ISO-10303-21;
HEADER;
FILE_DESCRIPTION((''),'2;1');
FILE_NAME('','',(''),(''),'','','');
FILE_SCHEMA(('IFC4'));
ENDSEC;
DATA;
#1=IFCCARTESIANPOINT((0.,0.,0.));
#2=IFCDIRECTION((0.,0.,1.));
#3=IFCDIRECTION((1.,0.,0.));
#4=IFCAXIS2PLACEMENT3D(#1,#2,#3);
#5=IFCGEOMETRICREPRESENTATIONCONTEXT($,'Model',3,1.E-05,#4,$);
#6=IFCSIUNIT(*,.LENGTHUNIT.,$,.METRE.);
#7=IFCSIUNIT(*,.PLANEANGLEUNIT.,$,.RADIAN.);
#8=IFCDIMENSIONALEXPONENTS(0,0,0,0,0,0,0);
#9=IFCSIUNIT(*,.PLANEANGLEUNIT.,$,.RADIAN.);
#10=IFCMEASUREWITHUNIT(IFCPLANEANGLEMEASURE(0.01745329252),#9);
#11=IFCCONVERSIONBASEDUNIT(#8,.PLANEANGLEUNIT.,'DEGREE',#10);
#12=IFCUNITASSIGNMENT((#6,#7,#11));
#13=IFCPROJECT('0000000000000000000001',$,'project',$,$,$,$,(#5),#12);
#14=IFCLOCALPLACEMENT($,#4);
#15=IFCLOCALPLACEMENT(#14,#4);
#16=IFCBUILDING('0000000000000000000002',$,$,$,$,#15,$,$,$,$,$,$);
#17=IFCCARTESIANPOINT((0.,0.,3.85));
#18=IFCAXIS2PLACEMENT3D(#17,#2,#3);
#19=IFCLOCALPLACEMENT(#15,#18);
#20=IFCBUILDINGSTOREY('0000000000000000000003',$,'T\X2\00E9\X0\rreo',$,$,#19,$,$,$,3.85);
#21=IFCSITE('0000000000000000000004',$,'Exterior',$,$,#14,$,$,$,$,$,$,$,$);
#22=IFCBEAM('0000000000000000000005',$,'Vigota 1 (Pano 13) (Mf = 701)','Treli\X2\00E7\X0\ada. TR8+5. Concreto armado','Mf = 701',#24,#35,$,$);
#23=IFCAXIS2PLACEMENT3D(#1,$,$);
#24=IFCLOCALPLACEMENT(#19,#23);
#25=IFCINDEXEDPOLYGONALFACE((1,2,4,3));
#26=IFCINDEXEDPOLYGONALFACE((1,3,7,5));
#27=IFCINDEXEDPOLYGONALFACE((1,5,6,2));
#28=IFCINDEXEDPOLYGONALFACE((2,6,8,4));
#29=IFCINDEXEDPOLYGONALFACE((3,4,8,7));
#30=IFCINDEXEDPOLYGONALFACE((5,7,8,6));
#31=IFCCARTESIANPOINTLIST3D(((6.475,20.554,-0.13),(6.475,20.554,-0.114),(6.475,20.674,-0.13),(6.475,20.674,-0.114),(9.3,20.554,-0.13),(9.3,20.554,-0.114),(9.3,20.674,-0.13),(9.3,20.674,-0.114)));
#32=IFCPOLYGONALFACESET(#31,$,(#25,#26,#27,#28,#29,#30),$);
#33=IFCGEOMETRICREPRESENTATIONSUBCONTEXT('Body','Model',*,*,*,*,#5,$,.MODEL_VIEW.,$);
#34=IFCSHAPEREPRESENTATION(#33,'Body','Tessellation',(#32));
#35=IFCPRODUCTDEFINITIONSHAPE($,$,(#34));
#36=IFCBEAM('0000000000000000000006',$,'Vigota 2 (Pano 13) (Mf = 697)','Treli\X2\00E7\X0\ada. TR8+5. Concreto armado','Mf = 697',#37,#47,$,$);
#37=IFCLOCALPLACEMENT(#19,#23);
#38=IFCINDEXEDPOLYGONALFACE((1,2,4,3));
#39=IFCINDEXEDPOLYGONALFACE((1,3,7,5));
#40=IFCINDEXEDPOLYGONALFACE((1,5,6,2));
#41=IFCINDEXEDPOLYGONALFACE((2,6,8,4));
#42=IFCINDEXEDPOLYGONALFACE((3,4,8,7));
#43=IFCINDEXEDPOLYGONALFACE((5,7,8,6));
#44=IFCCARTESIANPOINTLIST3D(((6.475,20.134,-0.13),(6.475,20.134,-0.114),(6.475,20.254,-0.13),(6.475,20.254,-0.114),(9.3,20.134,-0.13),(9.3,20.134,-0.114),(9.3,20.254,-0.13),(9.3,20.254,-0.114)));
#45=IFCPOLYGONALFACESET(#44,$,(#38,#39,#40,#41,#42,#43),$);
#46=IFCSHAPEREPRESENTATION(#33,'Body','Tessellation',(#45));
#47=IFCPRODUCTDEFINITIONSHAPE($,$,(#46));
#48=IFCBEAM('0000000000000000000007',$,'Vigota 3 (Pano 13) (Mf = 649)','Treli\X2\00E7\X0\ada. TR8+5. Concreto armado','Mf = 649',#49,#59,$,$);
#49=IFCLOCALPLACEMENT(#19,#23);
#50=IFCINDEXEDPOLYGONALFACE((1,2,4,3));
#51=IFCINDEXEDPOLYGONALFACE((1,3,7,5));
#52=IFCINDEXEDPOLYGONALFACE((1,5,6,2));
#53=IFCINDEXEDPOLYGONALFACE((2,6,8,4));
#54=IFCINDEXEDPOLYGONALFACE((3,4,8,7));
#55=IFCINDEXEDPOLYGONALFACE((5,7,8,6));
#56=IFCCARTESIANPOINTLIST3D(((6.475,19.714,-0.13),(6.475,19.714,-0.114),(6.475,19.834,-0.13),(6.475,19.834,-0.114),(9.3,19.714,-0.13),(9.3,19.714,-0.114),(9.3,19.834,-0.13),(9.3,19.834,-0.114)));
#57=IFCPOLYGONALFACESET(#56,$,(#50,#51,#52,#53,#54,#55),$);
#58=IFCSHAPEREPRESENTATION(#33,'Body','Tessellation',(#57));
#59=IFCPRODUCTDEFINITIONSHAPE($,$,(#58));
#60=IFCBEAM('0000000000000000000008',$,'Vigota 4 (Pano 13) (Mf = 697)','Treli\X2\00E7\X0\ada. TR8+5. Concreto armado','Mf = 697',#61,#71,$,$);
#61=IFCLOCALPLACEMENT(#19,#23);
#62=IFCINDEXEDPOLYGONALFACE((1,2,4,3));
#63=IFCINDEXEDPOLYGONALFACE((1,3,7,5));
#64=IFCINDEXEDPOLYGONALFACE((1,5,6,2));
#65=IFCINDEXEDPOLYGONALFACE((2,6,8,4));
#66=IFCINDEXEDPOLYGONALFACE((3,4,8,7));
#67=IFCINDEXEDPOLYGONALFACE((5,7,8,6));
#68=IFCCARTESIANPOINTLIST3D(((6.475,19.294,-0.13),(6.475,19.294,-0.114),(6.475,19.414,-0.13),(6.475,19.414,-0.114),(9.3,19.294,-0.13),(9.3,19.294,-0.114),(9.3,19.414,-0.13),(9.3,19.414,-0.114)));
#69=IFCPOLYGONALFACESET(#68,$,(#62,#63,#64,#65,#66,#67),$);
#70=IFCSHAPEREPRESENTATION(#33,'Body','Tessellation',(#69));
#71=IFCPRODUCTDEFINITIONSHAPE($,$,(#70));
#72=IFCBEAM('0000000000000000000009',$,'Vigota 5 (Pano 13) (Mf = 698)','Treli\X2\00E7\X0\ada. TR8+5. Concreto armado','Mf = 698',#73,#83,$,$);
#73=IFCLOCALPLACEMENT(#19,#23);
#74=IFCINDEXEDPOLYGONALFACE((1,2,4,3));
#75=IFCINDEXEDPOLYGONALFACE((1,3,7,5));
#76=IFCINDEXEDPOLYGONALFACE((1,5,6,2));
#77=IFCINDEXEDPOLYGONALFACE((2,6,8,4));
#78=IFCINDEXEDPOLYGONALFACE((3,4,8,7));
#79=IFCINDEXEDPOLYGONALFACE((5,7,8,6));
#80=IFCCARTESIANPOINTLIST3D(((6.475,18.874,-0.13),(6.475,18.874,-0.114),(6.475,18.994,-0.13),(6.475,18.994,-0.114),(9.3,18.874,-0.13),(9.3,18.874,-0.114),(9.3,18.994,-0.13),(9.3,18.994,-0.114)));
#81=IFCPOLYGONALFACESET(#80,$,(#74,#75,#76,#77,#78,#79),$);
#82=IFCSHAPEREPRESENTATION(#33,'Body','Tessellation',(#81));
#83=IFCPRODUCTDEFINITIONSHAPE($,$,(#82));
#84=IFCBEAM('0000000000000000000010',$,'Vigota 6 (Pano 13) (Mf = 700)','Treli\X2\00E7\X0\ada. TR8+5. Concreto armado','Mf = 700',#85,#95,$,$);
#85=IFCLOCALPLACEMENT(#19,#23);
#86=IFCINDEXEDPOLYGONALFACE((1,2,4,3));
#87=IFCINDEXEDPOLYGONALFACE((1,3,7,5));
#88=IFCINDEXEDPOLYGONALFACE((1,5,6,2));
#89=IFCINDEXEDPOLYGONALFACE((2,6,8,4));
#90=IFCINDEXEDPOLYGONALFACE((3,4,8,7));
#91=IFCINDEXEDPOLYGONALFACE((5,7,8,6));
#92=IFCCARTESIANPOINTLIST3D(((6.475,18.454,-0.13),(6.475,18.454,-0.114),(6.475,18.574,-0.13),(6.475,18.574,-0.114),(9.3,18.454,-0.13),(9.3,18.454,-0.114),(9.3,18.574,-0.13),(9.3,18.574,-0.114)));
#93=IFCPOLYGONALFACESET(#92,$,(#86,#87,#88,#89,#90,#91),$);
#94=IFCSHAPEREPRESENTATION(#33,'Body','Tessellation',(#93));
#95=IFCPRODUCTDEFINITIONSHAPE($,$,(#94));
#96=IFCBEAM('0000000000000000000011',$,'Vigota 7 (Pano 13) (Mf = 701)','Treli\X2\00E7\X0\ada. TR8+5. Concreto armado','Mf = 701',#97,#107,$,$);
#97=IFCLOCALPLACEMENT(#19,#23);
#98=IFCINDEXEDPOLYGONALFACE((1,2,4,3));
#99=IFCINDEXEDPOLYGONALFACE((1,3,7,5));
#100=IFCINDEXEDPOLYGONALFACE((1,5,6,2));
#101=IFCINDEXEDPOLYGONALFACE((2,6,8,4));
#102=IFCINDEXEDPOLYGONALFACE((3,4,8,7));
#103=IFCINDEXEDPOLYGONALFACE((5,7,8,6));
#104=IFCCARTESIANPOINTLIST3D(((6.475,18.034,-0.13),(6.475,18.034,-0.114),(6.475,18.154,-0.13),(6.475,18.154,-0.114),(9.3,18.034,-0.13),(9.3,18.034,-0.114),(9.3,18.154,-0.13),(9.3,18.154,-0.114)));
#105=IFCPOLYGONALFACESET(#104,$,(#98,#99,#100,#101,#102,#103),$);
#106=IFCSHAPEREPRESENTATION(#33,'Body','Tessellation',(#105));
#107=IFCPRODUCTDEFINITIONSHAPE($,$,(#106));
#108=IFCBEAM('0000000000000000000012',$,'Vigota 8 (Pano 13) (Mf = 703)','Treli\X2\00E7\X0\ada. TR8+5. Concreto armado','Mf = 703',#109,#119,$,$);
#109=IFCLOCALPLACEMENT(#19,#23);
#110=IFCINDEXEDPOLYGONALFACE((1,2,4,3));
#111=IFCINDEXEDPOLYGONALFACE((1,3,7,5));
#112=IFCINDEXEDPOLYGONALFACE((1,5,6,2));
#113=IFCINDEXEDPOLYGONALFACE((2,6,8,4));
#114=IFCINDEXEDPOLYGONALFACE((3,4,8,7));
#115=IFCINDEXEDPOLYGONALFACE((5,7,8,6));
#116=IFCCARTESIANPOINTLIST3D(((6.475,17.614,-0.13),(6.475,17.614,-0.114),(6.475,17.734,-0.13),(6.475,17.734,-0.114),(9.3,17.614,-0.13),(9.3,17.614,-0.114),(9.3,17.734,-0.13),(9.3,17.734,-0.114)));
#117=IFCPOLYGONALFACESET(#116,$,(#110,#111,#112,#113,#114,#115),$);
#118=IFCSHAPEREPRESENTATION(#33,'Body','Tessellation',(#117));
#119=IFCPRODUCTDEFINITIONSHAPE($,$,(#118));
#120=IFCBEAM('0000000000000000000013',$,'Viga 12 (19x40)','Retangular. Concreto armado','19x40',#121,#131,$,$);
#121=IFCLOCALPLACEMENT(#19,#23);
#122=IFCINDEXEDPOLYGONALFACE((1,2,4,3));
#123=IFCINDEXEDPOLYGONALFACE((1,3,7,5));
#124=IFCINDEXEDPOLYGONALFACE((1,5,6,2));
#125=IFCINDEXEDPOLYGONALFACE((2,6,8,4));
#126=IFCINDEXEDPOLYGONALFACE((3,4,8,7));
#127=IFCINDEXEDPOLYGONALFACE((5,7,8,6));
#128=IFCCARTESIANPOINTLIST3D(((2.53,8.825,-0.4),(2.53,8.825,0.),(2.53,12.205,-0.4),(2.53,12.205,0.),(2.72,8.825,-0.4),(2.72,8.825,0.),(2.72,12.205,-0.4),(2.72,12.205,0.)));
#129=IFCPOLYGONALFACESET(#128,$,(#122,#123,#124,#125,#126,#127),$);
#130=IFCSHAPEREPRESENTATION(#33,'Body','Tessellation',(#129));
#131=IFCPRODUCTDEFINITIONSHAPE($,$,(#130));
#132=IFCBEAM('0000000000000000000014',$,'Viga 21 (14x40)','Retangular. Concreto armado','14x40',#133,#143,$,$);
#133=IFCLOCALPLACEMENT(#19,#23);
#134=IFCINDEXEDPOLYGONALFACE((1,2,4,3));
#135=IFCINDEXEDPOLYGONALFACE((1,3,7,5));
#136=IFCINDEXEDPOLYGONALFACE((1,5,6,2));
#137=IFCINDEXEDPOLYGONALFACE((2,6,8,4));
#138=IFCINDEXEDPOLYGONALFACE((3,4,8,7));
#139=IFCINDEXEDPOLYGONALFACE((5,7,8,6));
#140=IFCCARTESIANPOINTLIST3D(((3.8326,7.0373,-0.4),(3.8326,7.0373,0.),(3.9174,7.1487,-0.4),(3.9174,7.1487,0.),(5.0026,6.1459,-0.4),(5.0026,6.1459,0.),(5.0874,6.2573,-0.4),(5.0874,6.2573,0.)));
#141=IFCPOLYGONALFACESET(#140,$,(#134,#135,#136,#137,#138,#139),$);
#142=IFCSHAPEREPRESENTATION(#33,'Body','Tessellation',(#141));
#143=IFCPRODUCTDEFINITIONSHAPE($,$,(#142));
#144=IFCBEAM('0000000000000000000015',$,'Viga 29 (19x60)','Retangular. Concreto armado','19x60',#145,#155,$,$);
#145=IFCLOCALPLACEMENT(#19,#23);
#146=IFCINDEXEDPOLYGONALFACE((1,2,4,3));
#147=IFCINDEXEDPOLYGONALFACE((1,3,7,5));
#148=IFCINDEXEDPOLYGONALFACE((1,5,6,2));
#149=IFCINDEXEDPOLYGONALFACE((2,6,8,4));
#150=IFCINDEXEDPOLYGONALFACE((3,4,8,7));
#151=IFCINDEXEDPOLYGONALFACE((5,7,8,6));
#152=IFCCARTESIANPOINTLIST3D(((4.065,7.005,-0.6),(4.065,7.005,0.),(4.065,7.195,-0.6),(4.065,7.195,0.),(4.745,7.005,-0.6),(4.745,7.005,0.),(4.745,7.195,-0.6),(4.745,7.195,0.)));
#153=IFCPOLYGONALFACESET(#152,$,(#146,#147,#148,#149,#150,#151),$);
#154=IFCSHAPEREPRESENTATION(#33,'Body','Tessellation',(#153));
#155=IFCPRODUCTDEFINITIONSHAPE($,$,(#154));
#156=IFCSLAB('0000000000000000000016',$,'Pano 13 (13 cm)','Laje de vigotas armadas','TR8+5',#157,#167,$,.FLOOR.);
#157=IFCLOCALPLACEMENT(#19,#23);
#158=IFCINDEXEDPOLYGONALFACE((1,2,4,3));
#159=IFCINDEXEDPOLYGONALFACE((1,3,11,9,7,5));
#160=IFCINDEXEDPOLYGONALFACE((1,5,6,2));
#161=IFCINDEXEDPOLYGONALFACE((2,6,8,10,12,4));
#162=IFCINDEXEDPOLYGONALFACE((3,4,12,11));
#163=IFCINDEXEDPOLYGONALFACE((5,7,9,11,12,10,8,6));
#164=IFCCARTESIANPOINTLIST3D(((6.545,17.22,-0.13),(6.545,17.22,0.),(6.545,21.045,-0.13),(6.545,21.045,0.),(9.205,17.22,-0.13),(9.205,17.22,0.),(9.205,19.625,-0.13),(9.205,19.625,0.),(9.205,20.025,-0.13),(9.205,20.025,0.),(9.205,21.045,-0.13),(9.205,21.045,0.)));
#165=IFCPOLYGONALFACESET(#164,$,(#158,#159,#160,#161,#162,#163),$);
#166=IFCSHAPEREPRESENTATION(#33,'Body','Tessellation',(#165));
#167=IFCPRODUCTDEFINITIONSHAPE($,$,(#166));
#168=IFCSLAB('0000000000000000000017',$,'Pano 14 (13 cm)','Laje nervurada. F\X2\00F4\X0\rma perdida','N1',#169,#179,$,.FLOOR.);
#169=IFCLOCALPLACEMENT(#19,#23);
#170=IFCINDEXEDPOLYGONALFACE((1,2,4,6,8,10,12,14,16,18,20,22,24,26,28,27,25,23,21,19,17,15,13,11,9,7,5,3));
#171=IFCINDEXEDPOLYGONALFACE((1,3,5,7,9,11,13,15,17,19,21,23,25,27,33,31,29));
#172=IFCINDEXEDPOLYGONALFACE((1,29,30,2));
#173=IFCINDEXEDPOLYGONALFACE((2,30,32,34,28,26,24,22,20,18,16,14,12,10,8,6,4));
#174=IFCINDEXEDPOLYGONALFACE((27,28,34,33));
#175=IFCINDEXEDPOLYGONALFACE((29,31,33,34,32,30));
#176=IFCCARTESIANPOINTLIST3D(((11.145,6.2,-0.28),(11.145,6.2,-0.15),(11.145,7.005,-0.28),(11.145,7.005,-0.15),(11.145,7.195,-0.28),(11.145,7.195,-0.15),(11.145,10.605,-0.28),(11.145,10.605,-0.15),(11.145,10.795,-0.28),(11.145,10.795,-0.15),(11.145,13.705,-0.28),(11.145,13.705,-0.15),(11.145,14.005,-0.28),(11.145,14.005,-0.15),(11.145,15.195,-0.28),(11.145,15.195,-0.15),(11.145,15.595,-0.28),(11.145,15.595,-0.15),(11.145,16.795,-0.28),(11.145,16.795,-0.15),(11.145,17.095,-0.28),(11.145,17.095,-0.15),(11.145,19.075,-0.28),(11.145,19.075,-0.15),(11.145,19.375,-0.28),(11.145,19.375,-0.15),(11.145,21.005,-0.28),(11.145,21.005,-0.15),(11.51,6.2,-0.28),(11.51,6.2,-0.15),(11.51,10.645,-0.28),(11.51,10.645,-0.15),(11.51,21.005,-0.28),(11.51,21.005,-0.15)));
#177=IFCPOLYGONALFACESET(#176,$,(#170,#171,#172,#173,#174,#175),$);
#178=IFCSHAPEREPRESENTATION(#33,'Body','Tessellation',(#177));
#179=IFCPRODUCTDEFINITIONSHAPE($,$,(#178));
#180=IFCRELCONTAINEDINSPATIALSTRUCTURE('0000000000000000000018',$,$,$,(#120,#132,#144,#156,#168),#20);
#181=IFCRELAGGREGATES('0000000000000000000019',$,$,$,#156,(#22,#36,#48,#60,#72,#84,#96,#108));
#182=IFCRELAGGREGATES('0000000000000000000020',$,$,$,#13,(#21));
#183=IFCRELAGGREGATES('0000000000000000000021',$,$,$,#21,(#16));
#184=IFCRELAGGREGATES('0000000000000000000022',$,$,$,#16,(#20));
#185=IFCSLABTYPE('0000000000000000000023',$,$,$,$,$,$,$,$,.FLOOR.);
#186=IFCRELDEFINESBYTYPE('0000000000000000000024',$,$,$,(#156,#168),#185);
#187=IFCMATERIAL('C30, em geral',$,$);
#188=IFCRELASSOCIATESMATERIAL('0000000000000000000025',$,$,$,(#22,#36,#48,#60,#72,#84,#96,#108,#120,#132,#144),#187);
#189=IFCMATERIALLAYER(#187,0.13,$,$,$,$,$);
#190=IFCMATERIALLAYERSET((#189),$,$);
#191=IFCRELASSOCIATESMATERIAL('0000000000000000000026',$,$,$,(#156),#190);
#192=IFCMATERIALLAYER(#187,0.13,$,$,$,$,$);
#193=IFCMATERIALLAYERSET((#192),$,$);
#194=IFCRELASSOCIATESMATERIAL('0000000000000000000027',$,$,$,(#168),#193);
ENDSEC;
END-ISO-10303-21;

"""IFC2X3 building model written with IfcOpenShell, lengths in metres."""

from ifc_helpers import new_model, entity, si_unit, converted_unit, frame, frame_2d, origin_with_axes, place, context, subcontext, project, spatial, polyline, rectangle, outline, extrude, material, layer, layer_set, layer_usage, type_object, element, aggregate, save


model = new_model("IFC2X3")

# Units and contexts
model_context = context("Model", 3, precision=1e-05, world=origin_with_axes())
body_context = subcontext(model_context, "Body", "Model", "MODEL_VIEW")
ifc_project = project(units=[si_unit("LENGTHUNIT", "METRE"), si_unit("PLANEANGLEUNIT", "RADIAN"), converted_unit("PLANEANGLEUNIT", "DEGREE", entity("IfcPlaneAngleMeasure", 0.01745329252), si_unit("PLANEANGLEUNIT", "RADIAN"), dimensions=[0, 0, 0, 0, 0, 0, 0])], contexts=[model_context])

# Site, building, storey
site_placement = place(None, origin_with_axes())
site = spatial("IfcSite", under=ifc_project, at=site_placement, Name="Exterior")
building_placement = place(site_placement, origin_with_axes())
building = spatial("IfcBuilding", under=site, at=building_placement)
storey_placement = place(building_placement, frame((0.0, 0.0, 3.85), z_axis=(0.0, 0.0, 1.0), x_axis=(1.0, 0.0, 0.0)))
storey = spatial("IfcBuildingStorey", under=building, at=storey_placement, Name="Térreo", Elevation=3.85)

# Beams
ifc_material_1 = material(Name="C30, em geral")
beam_1_placement = place(storey_placement, frame((6.475, 20.614, -0.122), z_axis=(1.0, 0.0, 0.0), x_axis=(0.0, 1.0, 0.0)))
beam_1 = element("IfcBeam", 1, at=beam_1_placement, material=ifc_material_1, Name="Vigota 1 (Pano 13) (Mf = 701)", Description="Treliçada. TR8+5. Concreto armado", ObjectType="Mf = 701", context=body_context, shape_type="SweptSolid", body=[
    extrude(outline(polyline([(0.06, 0.008), (-0.06, 0.008), (-0.06, -0.008), (0.06, -0.008), (0.06, 0.008)])), origin_with_axes(), (0.0, 0.0, 1.0), 2.825),
])
beam_2_placement = place(storey_placement, frame((6.475, 20.194, -0.122), z_axis=(1.0, 0.0, 0.0), x_axis=(0.0, 1.0, 0.0)))
beam_2 = element("IfcBeam", 2, at=beam_2_placement, material=ifc_material_1, Name="Vigota 2 (Pano 13) (Mf = 697)", Description="Treliçada. TR8+5. Concreto armado", ObjectType="Mf = 697", context=body_context, shape_type="SweptSolid", body=[
    extrude(outline(polyline([(0.06, 0.008), (-0.06, 0.008), (-0.06, -0.008), (0.06, -0.008), (0.06, 0.008)])), origin_with_axes(), (0.0, 0.0, 1.0), 2.825),
])
beam_3_placement = place(storey_placement, frame((6.475, 19.774, -0.122), z_axis=(1.0, 0.0, 0.0), x_axis=(0.0, 1.0, 0.0)))
beam_3 = element("IfcBeam", 3, at=beam_3_placement, material=ifc_material_1, Name="Vigota 3 (Pano 13) (Mf = 649)", Description="Treliçada. TR8+5. Concreto armado", ObjectType="Mf = 649", context=body_context, shape_type="SweptSolid", body=[
    extrude(outline(polyline([(0.06, 0.008), (-0.06, 0.008), (-0.06, -0.008), (0.06, -0.008), (0.06, 0.008)])), origin_with_axes(), (0.0, 0.0, 1.0), 2.825),
])
beam_4_placement = place(storey_placement, frame((6.475, 19.354, -0.122), z_axis=(1.0, 0.0, 0.0), x_axis=(0.0, 1.0, 0.0)))
beam_4 = element("IfcBeam", 4, at=beam_4_placement, material=ifc_material_1, Name="Vigota 4 (Pano 13) (Mf = 697)", Description="Treliçada. TR8+5. Concreto armado", ObjectType="Mf = 697", context=body_context, shape_type="SweptSolid", body=[
    extrude(outline(polyline([(0.06, 0.008), (-0.06, 0.008), (-0.06, -0.008), (0.06, -0.008), (0.06, 0.008)])), origin_with_axes(), (0.0, 0.0, 1.0), 2.825),
])
beam_5_placement = place(storey_placement, frame((6.475, 18.934, -0.122), z_axis=(1.0, 0.0, 0.0), x_axis=(0.0, 1.0, 0.0)))
beam_5 = element("IfcBeam", 5, at=beam_5_placement, material=ifc_material_1, Name="Vigota 5 (Pano 13) (Mf = 698)", Description="Treliçada. TR8+5. Concreto armado", ObjectType="Mf = 698", context=body_context, shape_type="SweptSolid", body=[
    extrude(outline(polyline([(0.06, 0.008), (-0.06, 0.008), (-0.06, -0.008), (0.06, -0.008), (0.06, 0.008)])), origin_with_axes(), (0.0, 0.0, 1.0), 2.825),
])
beam_6_placement = place(storey_placement, frame((6.475, 18.514, -0.122), z_axis=(1.0, 0.0, 0.0), x_axis=(0.0, 1.0, 0.0)))
beam_6 = element("IfcBeam", 6, at=beam_6_placement, material=ifc_material_1, Name="Vigota 6 (Pano 13) (Mf = 700)", Description="Treliçada. TR8+5. Concreto armado", ObjectType="Mf = 700", context=body_context, shape_type="SweptSolid", body=[
    extrude(outline(polyline([(0.06, 0.008), (-0.06, 0.008), (-0.06, -0.008), (0.06, -0.008), (0.06, 0.008)])), origin_with_axes(), (0.0, 0.0, 1.0), 2.825),
])
beam_7_placement = place(storey_placement, frame((6.475, 18.094, -0.122), z_axis=(1.0, 0.0, 0.0), x_axis=(0.0, 1.0, 0.0)))
beam_7 = element("IfcBeam", 7, at=beam_7_placement, material=ifc_material_1, Name="Vigota 7 (Pano 13) (Mf = 701)", Description="Treliçada. TR8+5. Concreto armado", ObjectType="Mf = 701", context=body_context, shape_type="SweptSolid", body=[
    extrude(outline(polyline([(0.06, 0.008), (-0.06, 0.008), (-0.06, -0.008), (0.06, -0.008), (0.06, 0.008)])), origin_with_axes(), (0.0, 0.0, 1.0), 2.825),
])
beam_8_placement = place(storey_placement, frame((6.475, 17.674, -0.122), z_axis=(1.0, 0.0, 0.0), x_axis=(0.0, 1.0, 0.0)))
beam_8 = element("IfcBeam", 8, at=beam_8_placement, material=ifc_material_1, Name="Vigota 8 (Pano 13) (Mf = 703)", Description="Treliçada. TR8+5. Concreto armado", ObjectType="Mf = 703", context=body_context, shape_type="SweptSolid", body=[
    extrude(outline(polyline([(0.06, 0.008), (-0.06, 0.008), (-0.06, -0.008), (0.06, -0.008), (0.06, 0.008)])), origin_with_axes(), (0.0, 0.0, 1.0), 2.825),
])

# Beams
beam_9_placement = place(storey_placement, frame((2.625, 8.825, 0.0), z_axis=(0.0, 1.0, 0.0), x_axis=(-1.0, 0.0, 0.0)))
element("IfcBeam", 9, at=beam_9_placement, inside=storey, material=ifc_material_1, Name="Viga 12 (19x40)", Description="Retangular. Concreto armado", ObjectType="19x40", context=body_context, shape_type="SweptSolid", body=[
    extrude(rectangle(XDim=0.19, YDim=0.4, at=frame_2d((0.0, -0.2), x_axis=(1.0, 0.0))), origin_with_axes(), (0.0, 0.0, 1.0), 3.38),
])
beam_10_placement = place(storey_placement, frame((3.875, 7.093, 0.0), z_axis=(0.795432, -0.606043, 0.0), x_axis=(0.606043, 0.795432, 0.0)))
element("IfcBeam", 10, at=beam_10_placement, inside=storey, material=ifc_material_1, Name="Viga 21 (14x40)", Description="Retangular. Concreto armado", ObjectType="14x40", context=body_context, shape_type="SweptSolid", body=[
    extrude(rectangle(XDim=0.14, YDim=0.4, at=frame_2d((0.0, -0.2), x_axis=(1.0, 0.0))), origin_with_axes(), (0.0, 0.0, 1.0), 1.4709),
])
beam_11_placement = place(storey_placement, frame((4.065, 7.1, 0.0), z_axis=(1.0, 0.0, 0.0), x_axis=(0.0, 1.0, 0.0)))
element("IfcBeam", 11, at=beam_11_placement, inside=storey, material=ifc_material_1, Name="Viga 29 (19x60)", Description="Retangular. Concreto armado", ObjectType="19x60", context=body_context, shape_type="SweptSolid", body=[
    extrude(rectangle(XDim=0.19, YDim=0.6, at=frame_2d((0.0, -0.3), x_axis=(1.0, 0.0))), origin_with_axes(), (0.0, 0.0, 1.0), 0.68),
])

# Slab
slab_type = type_object("IfcSlabType", PredefinedType="FLOOR")
ifc_layer_1 = layer(ifc_material_1, 0.13)
ifc_layer_set_1 = layer_set([ifc_layer_1])
ifc_layer_usage_1 = layer_usage(ifc_layer_set_1, "AXIS3", "POSITIVE", 0.0)
slab_1_placement = place(storey_placement, frame((0.0, 0.0, -0.13), z_axis=(0.0, 0.0, 1.0), x_axis=(1.0, 0.0, 0.0)))
slab_1 = element("IfcSlab", 12, at=slab_1_placement, inside=storey, type_object=slab_type, material=ifc_layer_usage_1, Name="Pano 13 (13 cm)", Description="Laje de vigotas armadas", ObjectType="TR8+5", PredefinedType="FLOOR", context=body_context, shape_type="SweptSolid", body=[
    extrude(outline(polyline([(9.205, 19.625), (9.205, 20.025), (9.205, 21.045), (6.545, 21.045), (6.545, 17.22), (9.205, 17.22), (9.205, 19.625)])), origin_with_axes(), (0.0, 0.0, 1.0), 0.13),
])
aggregate(slab_1, [beam_1, beam_2, beam_3, beam_4, beam_5, beam_6, beam_7, beam_8])

# Slab
ifc_layer_2 = layer(ifc_material_1, 0.13)
ifc_layer_set_2 = layer_set([ifc_layer_2])
ifc_layer_usage_2 = layer_usage(ifc_layer_set_2, "AXIS3", "POSITIVE", 0.0)
slab_2_placement = place(storey_placement, frame((0.0, 0.0, -0.28), z_axis=(0.0, 0.0, 1.0), x_axis=(1.0, 0.0, 0.0)))
element("IfcSlab", 13, at=slab_2_placement, inside=storey, type_object=slab_type, material=ifc_layer_usage_2, Name="Pano 14 (13 cm)", Description="Laje nervurada. Fôrma perdida", ObjectType="N1", PredefinedType="FLOOR", context=body_context, shape_type="SweptSolid", body=[
    extrude(outline(polyline([(11.51, 21.005), (11.145, 21.005), (11.145, 19.375), (11.145, 19.075), (11.145, 17.095), (11.145, 16.795), (11.145, 15.595), (11.145, 15.195), (11.145, 14.005), (11.145, 13.705), (11.145, 10.795), (11.145, 10.605), (11.145, 7.195), (11.145, 7.005), (11.145, 6.2), (11.51, 6.2), (11.51, 10.645), (11.51, 21.005)])), origin_with_axes(), (0.0, 0.0, 1.0), 0.13),
])

save(model, "model.ifc")
